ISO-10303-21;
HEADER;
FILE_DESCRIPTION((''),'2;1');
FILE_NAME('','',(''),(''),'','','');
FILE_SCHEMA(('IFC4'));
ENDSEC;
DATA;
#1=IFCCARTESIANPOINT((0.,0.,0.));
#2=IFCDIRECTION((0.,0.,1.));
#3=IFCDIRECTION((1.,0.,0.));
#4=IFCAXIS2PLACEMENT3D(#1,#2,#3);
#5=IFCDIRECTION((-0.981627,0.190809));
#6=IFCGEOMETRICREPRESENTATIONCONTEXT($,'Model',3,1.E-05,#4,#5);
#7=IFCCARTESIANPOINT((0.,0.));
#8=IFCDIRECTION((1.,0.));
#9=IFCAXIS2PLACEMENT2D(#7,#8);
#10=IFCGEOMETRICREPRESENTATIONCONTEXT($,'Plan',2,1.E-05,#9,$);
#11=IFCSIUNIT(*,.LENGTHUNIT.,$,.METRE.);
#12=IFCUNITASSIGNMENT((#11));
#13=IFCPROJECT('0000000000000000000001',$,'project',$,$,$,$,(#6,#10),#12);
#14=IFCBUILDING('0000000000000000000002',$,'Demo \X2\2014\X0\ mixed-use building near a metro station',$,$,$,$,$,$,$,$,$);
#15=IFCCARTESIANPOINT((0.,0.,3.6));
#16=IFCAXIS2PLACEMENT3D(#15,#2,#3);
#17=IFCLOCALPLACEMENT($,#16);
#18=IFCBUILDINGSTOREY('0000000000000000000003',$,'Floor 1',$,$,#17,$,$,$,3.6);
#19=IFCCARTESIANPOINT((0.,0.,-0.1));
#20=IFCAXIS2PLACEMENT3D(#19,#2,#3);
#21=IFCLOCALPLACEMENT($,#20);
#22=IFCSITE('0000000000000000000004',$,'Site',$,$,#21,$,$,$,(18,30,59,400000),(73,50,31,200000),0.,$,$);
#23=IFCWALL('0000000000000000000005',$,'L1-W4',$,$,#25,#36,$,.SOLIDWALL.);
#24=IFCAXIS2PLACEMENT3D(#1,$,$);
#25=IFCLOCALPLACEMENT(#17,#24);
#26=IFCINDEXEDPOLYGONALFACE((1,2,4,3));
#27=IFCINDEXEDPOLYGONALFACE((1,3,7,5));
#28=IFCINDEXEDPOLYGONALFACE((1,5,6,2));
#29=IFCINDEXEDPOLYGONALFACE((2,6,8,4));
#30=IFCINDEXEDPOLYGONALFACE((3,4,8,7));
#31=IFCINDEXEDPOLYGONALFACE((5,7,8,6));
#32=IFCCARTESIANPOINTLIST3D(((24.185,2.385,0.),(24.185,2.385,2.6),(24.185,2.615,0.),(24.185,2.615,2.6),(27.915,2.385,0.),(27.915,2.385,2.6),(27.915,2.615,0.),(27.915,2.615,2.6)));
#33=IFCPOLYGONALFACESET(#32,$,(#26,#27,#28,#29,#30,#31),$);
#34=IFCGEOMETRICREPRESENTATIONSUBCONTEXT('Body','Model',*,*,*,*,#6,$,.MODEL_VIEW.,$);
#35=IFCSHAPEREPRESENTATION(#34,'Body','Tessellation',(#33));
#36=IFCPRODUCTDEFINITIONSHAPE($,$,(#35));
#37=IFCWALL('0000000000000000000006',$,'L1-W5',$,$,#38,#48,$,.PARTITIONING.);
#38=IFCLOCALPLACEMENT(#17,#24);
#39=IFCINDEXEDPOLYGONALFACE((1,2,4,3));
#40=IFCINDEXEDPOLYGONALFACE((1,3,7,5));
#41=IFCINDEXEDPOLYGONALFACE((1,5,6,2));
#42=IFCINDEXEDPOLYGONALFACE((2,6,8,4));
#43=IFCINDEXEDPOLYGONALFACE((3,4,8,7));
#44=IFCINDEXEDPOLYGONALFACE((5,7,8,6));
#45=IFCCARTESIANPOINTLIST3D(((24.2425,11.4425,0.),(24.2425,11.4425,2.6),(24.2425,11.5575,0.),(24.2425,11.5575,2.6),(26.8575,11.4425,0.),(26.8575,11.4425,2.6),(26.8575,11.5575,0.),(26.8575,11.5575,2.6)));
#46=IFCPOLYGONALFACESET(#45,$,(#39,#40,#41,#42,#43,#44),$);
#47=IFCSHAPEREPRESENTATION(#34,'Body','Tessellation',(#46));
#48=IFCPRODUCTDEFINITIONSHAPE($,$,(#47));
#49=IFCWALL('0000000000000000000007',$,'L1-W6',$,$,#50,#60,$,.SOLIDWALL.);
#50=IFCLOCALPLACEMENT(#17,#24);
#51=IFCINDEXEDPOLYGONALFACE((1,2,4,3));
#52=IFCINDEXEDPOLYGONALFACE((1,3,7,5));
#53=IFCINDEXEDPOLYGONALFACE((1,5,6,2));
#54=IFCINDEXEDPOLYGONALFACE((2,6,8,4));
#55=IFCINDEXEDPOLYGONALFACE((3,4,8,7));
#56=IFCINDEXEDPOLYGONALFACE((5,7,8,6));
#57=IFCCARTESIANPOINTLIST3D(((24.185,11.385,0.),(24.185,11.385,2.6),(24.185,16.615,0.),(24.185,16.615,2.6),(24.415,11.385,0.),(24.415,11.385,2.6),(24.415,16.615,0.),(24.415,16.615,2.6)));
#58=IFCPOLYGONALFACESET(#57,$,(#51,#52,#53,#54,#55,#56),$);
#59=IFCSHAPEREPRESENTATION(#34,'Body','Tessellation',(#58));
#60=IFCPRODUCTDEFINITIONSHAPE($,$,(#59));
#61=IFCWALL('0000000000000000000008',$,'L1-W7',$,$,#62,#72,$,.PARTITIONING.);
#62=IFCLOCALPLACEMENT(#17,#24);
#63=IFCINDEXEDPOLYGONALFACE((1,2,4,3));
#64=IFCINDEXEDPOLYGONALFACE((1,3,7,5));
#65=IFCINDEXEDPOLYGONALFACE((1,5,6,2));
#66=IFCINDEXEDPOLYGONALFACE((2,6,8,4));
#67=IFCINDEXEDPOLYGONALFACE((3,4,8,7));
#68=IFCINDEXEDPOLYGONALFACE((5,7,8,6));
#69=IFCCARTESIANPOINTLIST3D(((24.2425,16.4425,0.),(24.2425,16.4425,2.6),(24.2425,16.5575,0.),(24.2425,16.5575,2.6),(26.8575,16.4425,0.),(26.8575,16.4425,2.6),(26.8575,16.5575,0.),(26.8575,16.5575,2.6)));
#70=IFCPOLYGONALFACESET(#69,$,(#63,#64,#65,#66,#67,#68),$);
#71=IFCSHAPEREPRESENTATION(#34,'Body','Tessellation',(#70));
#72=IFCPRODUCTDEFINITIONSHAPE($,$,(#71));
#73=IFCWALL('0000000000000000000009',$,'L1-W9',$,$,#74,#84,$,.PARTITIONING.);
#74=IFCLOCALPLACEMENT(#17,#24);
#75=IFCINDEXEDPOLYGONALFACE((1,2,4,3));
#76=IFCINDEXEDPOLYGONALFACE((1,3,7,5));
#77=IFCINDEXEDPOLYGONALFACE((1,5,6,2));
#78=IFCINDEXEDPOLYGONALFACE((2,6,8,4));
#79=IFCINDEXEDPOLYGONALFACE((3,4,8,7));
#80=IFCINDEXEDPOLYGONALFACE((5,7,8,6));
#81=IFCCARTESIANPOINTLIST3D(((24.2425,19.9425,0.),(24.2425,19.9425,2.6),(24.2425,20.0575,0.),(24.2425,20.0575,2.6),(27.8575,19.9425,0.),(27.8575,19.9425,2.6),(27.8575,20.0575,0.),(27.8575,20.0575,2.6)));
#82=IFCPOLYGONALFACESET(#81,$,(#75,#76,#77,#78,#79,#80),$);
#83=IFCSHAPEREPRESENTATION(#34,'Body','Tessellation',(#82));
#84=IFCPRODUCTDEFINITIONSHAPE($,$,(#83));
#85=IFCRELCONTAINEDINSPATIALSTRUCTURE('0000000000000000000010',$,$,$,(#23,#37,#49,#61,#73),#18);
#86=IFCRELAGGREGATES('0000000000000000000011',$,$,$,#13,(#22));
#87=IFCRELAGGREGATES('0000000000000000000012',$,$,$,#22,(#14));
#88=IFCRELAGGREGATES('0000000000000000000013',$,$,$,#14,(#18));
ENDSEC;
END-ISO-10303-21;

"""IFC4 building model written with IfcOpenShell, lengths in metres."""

from ifc_helpers import new_model, si_unit, direction, frame, origin_with_axes, origin_2d_with_axis, place, context, subcontext, project, spatial, line, indexed_curve, outline, extrude, element, save


model = new_model("IFC4")

# Units and contexts
model_context = context("Model", 3, precision=1e-05, world=origin_with_axes(), true_north=direction((-0.981627, 0.190809)))
plan_context = context("Plan", 2, precision=1e-05, world=origin_2d_with_axis())
body_context = subcontext(model_context, "Body", "Model", "MODEL_VIEW")
ifc_project = project(units=[si_unit("LENGTHUNIT", "METRE")], contexts=[model_context, plan_context])

# Site, building, storey
site_placement = place(None, frame((0.0, 0.0, -0.1), z_axis=(0.0, 0.0, 1.0), x_axis=(1.0, 0.0, 0.0)))
site = spatial("IfcSite", under=ifc_project, at=site_placement, Name="Site", RefLatitude=(18, 30, 59, 400000), RefLongitude=(73, 50, 31, 200000), RefElevation=0.0)
building = spatial("IfcBuilding", under=site, Name="Demo — mixed-use building near a metro station")
storey_placement = place(None, frame((0.0, 0.0, 3.6), z_axis=(0.0, 0.0, 1.0), x_axis=(1.0, 0.0, 0.0)))
storey = spatial("IfcBuildingStorey", under=building, at=storey_placement, Name="Floor 1", Elevation=3.6)

# Walls
wall_1_placement = place(storey_placement, frame((0.0, 0.0, -3.6), z_axis=(0.0, 0.0, 1.0), x_axis=(1.0, 0.0, 0.0)))
element("IfcWall", 1, at=wall_1_placement, inside=storey, Name="L1-W4", PredefinedType="SOLIDWALL", context=body_context, shape_type="SweptSolid", body=[
    extrude(outline(indexed_curve([(24.185, 2.615), (27.915, 2.615), (27.915, 2.385), (24.185, 2.385)], segments=[line(1, 2, 3, 4, 1)])), frame((0.0, 0.0, 3.6), z_axis=(0.0, 0.0, 1.0), x_axis=(1.0, 0.0, 0.0)), (0.0, 0.0, 1.0), 2.6),
])
wall_2_placement = place(storey_placement, frame((0.0, 0.0, -3.6), z_axis=(0.0, 0.0, 1.0), x_axis=(1.0, 0.0, 0.0)))
element("IfcWall", 2, at=wall_2_placement, inside=storey, Name="L1-W5", PredefinedType="PARTITIONING", context=body_context, shape_type="SweptSolid", body=[
    extrude(outline(indexed_curve([(24.2425, 11.5575), (26.8575, 11.5575), (26.8575, 11.4425), (24.2425, 11.4425)], segments=[line(1, 2, 3, 4, 1)])), frame((0.0, 0.0, 3.6), z_axis=(0.0, 0.0, 1.0), x_axis=(1.0, 0.0, 0.0)), (0.0, 0.0, 1.0), 2.6),
])
wall_3_placement = place(storey_placement, frame((0.0, 0.0, -3.6), z_axis=(0.0, 0.0, 1.0), x_axis=(1.0, 0.0, 0.0)))
element("IfcWall", 3, at=wall_3_placement, inside=storey, Name="L1-W6", PredefinedType="SOLIDWALL", context=body_context, shape_type="SweptSolid", body=[
    extrude(outline(indexed_curve([(24.415, 16.615), (24.415, 11.385), (24.185, 11.385), (24.185, 16.615)], segments=[line(1, 2, 3, 4, 1)])), frame((0.0, 0.0, 3.6), z_axis=(0.0, 0.0, 1.0), x_axis=(1.0, 0.0, 0.0)), (0.0, 0.0, 1.0), 2.6),
])
wall_4_placement = place(storey_placement, frame((0.0, 0.0, -3.6), z_axis=(0.0, 0.0, 1.0), x_axis=(1.0, 0.0, 0.0)))
element("IfcWall", 4, at=wall_4_placement, inside=storey, Name="L1-W7", PredefinedType="PARTITIONING", context=body_context, shape_type="SweptSolid", body=[
    extrude(outline(indexed_curve([(26.8575, 16.4425), (24.2425, 16.4425), (24.2425, 16.5575), (26.8575, 16.5575)], segments=[line(1, 2, 3, 4, 1)])), frame((0.0, 0.0, 3.6), z_axis=(0.0, 0.0, 1.0), x_axis=(1.0, 0.0, 0.0)), (0.0, 0.0, 1.0), 2.6),
])

# Wall
wall_5_placement = place(storey_placement, frame((0.0, 0.0, -3.6), z_axis=(0.0, 0.0, 1.0), x_axis=(1.0, 0.0, 0.0)))
element("IfcWall", 5, at=wall_5_placement, inside=storey, Name="L1-W9", PredefinedType="PARTITIONING", context=body_context, shape_type="SweptSolid", body=[
    extrude(outline(indexed_curve([(27.8575, 19.9425), (24.2425, 19.9425), (24.2425, 20.0575), (27.8575, 20.0575)], segments=[line(1, 2, 3, 4, 1)])), frame((0.0, 0.0, 3.6), z_axis=(0.0, 0.0, 1.0), x_axis=(1.0, 0.0, 0.0)), (0.0, 0.0, 1.0), 2.6),
])

save(model, "model.ifc")
